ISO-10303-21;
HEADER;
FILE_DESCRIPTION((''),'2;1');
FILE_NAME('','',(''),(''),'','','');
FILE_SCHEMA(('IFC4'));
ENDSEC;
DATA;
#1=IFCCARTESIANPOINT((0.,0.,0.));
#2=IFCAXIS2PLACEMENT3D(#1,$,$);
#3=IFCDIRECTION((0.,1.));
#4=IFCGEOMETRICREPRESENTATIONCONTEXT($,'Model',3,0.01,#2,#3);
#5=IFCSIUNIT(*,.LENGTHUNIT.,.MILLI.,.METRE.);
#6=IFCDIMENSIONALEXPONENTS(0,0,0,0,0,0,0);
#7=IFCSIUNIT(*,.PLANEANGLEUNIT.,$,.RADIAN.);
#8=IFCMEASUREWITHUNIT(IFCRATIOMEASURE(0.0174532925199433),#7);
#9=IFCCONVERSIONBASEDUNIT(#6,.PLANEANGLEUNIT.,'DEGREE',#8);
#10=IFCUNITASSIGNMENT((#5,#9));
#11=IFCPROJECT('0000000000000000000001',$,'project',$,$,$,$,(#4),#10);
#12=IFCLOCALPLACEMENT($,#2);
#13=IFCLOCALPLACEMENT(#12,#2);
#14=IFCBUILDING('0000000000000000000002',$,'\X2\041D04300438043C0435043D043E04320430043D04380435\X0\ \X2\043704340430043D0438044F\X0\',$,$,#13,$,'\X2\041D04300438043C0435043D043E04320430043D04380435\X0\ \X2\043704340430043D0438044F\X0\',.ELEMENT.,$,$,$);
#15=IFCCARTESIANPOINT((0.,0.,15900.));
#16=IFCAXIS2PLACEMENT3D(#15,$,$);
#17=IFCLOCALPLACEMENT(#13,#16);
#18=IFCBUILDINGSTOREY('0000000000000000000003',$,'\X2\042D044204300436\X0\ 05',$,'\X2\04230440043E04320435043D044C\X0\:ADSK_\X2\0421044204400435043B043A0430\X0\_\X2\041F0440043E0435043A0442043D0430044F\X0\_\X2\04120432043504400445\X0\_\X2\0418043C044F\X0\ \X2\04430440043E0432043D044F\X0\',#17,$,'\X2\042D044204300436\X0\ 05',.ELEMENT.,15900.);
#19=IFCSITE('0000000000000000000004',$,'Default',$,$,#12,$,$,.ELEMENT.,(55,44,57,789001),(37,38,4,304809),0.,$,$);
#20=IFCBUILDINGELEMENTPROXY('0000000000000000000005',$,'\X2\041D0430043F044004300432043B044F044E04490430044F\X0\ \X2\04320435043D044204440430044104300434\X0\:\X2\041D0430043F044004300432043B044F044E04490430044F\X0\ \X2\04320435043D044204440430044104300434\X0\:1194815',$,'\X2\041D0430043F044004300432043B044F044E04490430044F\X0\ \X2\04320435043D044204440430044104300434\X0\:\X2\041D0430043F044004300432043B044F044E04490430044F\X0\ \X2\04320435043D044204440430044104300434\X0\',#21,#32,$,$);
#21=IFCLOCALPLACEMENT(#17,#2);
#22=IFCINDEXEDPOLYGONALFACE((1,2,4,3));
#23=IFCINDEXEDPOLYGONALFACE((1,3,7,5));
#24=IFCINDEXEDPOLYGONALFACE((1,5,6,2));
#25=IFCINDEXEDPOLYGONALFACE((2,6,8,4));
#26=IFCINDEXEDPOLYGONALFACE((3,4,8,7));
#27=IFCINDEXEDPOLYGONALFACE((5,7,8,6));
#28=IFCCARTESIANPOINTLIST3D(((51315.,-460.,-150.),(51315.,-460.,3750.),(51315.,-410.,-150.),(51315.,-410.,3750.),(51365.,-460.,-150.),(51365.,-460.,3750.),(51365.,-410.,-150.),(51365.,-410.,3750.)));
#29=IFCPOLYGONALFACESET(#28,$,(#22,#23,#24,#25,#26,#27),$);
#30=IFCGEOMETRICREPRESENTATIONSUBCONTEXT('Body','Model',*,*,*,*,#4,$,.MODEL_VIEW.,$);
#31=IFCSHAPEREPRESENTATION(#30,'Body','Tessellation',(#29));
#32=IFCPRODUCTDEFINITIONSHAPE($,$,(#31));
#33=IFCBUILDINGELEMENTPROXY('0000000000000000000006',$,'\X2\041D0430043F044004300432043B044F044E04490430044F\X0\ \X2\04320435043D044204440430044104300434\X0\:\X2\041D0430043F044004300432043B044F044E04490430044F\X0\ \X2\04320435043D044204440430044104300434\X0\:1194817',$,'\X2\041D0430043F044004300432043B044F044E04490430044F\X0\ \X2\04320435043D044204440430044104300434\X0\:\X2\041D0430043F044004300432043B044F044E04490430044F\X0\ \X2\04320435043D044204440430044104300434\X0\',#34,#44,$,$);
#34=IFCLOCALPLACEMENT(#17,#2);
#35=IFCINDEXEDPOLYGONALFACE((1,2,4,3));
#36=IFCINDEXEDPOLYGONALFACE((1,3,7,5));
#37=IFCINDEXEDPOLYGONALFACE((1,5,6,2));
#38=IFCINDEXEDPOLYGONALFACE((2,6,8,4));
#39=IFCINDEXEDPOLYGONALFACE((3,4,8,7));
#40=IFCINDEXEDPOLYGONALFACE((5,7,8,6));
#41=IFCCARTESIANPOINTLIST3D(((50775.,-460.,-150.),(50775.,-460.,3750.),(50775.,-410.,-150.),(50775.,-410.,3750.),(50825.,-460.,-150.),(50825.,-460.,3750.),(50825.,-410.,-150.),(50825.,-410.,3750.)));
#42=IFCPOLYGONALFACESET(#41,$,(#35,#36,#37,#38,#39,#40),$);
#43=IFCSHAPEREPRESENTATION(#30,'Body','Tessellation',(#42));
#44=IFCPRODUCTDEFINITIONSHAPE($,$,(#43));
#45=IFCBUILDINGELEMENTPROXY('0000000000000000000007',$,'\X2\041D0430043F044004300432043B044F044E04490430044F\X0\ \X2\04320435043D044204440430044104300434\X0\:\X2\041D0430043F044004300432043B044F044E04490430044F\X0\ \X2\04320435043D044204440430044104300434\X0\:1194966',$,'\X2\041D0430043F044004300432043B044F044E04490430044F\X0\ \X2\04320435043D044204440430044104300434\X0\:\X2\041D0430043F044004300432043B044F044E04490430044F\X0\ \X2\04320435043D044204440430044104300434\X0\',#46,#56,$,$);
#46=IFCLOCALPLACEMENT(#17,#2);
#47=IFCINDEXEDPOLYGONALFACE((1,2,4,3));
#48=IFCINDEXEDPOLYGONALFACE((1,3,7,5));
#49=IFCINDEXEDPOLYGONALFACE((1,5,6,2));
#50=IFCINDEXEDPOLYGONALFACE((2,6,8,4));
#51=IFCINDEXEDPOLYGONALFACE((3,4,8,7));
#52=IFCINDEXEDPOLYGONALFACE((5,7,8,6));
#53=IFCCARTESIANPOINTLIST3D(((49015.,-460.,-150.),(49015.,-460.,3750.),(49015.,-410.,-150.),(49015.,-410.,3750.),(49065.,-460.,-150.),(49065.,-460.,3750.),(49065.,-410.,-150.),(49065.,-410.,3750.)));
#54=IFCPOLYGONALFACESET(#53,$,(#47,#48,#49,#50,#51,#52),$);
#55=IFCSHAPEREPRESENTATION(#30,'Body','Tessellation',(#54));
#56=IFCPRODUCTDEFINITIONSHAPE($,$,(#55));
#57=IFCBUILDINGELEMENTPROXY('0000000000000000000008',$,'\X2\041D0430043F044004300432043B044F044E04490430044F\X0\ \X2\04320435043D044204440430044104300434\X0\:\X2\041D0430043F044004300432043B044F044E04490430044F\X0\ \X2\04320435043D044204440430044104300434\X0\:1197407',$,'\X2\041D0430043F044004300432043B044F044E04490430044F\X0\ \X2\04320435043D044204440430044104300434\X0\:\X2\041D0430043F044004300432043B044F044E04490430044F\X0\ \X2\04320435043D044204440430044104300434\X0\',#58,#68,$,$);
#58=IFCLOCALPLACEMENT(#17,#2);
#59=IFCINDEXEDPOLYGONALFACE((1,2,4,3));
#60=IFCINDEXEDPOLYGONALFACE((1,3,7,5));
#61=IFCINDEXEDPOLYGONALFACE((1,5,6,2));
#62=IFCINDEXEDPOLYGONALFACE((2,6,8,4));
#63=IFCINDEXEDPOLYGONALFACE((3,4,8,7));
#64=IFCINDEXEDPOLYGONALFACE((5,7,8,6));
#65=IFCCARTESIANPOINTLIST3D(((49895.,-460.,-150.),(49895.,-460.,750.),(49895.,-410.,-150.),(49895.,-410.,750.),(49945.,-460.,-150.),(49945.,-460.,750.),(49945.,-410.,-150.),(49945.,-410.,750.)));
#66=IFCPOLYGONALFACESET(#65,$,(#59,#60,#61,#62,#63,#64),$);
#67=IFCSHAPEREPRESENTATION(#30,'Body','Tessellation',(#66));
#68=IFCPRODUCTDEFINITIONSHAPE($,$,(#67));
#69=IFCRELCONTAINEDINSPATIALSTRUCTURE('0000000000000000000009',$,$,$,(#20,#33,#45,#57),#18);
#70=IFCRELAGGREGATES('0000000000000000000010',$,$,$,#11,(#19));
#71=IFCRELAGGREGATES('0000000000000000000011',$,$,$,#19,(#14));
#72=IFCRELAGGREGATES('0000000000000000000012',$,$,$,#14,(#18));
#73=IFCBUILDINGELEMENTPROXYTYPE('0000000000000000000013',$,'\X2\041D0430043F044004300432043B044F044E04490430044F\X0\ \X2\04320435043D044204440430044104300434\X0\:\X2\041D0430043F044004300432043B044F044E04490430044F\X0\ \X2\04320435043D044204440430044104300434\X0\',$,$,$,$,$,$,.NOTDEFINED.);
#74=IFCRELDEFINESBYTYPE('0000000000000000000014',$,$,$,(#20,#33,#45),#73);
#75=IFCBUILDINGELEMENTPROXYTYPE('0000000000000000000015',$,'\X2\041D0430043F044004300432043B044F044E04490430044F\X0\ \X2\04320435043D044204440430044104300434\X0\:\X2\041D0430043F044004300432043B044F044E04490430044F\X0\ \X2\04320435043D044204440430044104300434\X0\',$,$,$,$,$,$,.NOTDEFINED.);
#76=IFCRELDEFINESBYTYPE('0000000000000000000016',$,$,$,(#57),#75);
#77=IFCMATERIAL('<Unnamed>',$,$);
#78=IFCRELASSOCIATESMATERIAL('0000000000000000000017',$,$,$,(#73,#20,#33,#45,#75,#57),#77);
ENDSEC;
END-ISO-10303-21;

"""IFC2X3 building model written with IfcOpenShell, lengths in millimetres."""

from ifc_helpers import new_model, entity, si_unit, converted_unit, direction, frame, origin, origin_2d_with_axis, place, context, subcontext, project, spatial, rectangle, extrude, source, transform, mapped, material, type_object, type_shapes, element, save


model = new_model("IFC2X3")

# Units and contexts
model_context = context("Model", 3, precision=0.01, world=origin(), true_north=direction((0.0, 1.0)))
body_context = subcontext(model_context, "Body", "Model", "MODEL_VIEW")
ifc_project = project(units=[si_unit("LENGTHUNIT", "METRE", prefix="MILLI"), converted_unit("PLANEANGLEUNIT", "DEGREE", entity("IfcRatioMeasure", 0.0174532925199433), si_unit("PLANEANGLEUNIT", "RADIAN"), dimensions=[0, 0, 0, 0, 0, 0, 0])], contexts=[model_context])

# Site, building, storey
site_placement = place(None, origin())
site = spatial("IfcSite", under=ifc_project, at=site_placement, Name="Default", CompositionType="ELEMENT", RefLatitude=(55, 44, 57, 789001), RefLongitude=(37, 38, 4, 304809), RefElevation=0.0)
building_placement = place(site_placement, origin())
building = spatial("IfcBuilding", under=site, at=building_placement, Name="Наименование здания", LongName="Наименование здания", CompositionType="ELEMENT")
storey_placement = place(building_placement, frame((0.0, 0.0, 15900.0)))
storey = spatial("IfcBuildingStorey", under=building, at=storey_placement, Name="Этаж 05", ObjectType="Уровень:ADSK_Стрелка_Проектная_Вверх_Имя уровня", LongName="Этаж 05", CompositionType="ELEMENT", Elevation=15900.0)

# Building element proxies
ifc_material_1 = material(Name="<Unnamed>")
building_element_proxy_type_1 = type_object("IfcBuildingElementProxyType", Name="Направляющая вентфасад:Направляющая вентфасад", PredefinedType="NOTDEFINED", material=ifc_material_1)
shared_shape_1 = source(origin(), body_context, "Body", "SweptSolid", [
    extrude(rectangle(XDim=50.0, YDim=50.0, at=origin_2d_with_axis()), frame((25.0, -25.0, 0.0), z_axis=(0.0, 0.0, 1.0), x_axis=(-1.0, 0.0, 0.0)), (0.0, 0.0, 1.0), 3900.0),
])
type_shapes(building_element_proxy_type_1, [shared_shape_1])
for number, where, name in (
    (1, (51315.0, -410.0, -150.0), "Направляющая вентфасад:Направляющая вентфасад:1194815"),
    (2, (50775.0, -410.0, -150.0), "Направляющая вентфасад:Направляющая вентфасад:1194817"),
    (3, (49015.0, -410.0, -150.0), "Направляющая вентфасад:Направляющая вентфасад:1194966"),
):
    element("IfcBuildingElementProxy", number, at=place(storey_placement, frame(where)), inside=storey, type_object=building_element_proxy_type_1, material=ifc_material_1, Name=name, ObjectType="Направляющая вентфасад:Направляющая вентфасад", context=body_context, shape_type="MappedRepresentation", body=[
        mapped(shared_shape_1, transform((0.0, 0.0, 0.0), scale=1.0)),
    ])
building_element_proxy_type_2 = type_object("IfcBuildingElementProxyType", Name="Направляющая вентфасад:Направляющая вентфасад", PredefinedType="NOTDEFINED", material=ifc_material_1)
shared_shape_2 = source(origin(), body_context, "Body", "SweptSolid", [
    extrude(rectangle(XDim=50.0, YDim=50.0, at=origin_2d_with_axis()), frame((25.0, -25.0, 0.0), z_axis=(0.0, 0.0, 1.0), x_axis=(-1.0, 0.0, 0.0)), (0.0, 0.0, 1.0), 900.0),
])
type_shapes(building_element_proxy_type_2, [shared_shape_2])
proxy_1_placement = place(storey_placement, frame((49895.0, -410.0, -150.0)))
element("IfcBuildingElementProxy", 4, at=proxy_1_placement, inside=storey, type_object=building_element_proxy_type_2, material=ifc_material_1, Name="Направляющая вентфасад:Направляющая вентфасад:1197407", ObjectType="Направляющая вентфасад:Направляющая вентфасад", context=body_context, shape_type="MappedRepresentation", body=[
    mapped(shared_shape_2, transform((0.0, 0.0, 0.0), scale=1.0)),
])

save(model, "model.ifc")
